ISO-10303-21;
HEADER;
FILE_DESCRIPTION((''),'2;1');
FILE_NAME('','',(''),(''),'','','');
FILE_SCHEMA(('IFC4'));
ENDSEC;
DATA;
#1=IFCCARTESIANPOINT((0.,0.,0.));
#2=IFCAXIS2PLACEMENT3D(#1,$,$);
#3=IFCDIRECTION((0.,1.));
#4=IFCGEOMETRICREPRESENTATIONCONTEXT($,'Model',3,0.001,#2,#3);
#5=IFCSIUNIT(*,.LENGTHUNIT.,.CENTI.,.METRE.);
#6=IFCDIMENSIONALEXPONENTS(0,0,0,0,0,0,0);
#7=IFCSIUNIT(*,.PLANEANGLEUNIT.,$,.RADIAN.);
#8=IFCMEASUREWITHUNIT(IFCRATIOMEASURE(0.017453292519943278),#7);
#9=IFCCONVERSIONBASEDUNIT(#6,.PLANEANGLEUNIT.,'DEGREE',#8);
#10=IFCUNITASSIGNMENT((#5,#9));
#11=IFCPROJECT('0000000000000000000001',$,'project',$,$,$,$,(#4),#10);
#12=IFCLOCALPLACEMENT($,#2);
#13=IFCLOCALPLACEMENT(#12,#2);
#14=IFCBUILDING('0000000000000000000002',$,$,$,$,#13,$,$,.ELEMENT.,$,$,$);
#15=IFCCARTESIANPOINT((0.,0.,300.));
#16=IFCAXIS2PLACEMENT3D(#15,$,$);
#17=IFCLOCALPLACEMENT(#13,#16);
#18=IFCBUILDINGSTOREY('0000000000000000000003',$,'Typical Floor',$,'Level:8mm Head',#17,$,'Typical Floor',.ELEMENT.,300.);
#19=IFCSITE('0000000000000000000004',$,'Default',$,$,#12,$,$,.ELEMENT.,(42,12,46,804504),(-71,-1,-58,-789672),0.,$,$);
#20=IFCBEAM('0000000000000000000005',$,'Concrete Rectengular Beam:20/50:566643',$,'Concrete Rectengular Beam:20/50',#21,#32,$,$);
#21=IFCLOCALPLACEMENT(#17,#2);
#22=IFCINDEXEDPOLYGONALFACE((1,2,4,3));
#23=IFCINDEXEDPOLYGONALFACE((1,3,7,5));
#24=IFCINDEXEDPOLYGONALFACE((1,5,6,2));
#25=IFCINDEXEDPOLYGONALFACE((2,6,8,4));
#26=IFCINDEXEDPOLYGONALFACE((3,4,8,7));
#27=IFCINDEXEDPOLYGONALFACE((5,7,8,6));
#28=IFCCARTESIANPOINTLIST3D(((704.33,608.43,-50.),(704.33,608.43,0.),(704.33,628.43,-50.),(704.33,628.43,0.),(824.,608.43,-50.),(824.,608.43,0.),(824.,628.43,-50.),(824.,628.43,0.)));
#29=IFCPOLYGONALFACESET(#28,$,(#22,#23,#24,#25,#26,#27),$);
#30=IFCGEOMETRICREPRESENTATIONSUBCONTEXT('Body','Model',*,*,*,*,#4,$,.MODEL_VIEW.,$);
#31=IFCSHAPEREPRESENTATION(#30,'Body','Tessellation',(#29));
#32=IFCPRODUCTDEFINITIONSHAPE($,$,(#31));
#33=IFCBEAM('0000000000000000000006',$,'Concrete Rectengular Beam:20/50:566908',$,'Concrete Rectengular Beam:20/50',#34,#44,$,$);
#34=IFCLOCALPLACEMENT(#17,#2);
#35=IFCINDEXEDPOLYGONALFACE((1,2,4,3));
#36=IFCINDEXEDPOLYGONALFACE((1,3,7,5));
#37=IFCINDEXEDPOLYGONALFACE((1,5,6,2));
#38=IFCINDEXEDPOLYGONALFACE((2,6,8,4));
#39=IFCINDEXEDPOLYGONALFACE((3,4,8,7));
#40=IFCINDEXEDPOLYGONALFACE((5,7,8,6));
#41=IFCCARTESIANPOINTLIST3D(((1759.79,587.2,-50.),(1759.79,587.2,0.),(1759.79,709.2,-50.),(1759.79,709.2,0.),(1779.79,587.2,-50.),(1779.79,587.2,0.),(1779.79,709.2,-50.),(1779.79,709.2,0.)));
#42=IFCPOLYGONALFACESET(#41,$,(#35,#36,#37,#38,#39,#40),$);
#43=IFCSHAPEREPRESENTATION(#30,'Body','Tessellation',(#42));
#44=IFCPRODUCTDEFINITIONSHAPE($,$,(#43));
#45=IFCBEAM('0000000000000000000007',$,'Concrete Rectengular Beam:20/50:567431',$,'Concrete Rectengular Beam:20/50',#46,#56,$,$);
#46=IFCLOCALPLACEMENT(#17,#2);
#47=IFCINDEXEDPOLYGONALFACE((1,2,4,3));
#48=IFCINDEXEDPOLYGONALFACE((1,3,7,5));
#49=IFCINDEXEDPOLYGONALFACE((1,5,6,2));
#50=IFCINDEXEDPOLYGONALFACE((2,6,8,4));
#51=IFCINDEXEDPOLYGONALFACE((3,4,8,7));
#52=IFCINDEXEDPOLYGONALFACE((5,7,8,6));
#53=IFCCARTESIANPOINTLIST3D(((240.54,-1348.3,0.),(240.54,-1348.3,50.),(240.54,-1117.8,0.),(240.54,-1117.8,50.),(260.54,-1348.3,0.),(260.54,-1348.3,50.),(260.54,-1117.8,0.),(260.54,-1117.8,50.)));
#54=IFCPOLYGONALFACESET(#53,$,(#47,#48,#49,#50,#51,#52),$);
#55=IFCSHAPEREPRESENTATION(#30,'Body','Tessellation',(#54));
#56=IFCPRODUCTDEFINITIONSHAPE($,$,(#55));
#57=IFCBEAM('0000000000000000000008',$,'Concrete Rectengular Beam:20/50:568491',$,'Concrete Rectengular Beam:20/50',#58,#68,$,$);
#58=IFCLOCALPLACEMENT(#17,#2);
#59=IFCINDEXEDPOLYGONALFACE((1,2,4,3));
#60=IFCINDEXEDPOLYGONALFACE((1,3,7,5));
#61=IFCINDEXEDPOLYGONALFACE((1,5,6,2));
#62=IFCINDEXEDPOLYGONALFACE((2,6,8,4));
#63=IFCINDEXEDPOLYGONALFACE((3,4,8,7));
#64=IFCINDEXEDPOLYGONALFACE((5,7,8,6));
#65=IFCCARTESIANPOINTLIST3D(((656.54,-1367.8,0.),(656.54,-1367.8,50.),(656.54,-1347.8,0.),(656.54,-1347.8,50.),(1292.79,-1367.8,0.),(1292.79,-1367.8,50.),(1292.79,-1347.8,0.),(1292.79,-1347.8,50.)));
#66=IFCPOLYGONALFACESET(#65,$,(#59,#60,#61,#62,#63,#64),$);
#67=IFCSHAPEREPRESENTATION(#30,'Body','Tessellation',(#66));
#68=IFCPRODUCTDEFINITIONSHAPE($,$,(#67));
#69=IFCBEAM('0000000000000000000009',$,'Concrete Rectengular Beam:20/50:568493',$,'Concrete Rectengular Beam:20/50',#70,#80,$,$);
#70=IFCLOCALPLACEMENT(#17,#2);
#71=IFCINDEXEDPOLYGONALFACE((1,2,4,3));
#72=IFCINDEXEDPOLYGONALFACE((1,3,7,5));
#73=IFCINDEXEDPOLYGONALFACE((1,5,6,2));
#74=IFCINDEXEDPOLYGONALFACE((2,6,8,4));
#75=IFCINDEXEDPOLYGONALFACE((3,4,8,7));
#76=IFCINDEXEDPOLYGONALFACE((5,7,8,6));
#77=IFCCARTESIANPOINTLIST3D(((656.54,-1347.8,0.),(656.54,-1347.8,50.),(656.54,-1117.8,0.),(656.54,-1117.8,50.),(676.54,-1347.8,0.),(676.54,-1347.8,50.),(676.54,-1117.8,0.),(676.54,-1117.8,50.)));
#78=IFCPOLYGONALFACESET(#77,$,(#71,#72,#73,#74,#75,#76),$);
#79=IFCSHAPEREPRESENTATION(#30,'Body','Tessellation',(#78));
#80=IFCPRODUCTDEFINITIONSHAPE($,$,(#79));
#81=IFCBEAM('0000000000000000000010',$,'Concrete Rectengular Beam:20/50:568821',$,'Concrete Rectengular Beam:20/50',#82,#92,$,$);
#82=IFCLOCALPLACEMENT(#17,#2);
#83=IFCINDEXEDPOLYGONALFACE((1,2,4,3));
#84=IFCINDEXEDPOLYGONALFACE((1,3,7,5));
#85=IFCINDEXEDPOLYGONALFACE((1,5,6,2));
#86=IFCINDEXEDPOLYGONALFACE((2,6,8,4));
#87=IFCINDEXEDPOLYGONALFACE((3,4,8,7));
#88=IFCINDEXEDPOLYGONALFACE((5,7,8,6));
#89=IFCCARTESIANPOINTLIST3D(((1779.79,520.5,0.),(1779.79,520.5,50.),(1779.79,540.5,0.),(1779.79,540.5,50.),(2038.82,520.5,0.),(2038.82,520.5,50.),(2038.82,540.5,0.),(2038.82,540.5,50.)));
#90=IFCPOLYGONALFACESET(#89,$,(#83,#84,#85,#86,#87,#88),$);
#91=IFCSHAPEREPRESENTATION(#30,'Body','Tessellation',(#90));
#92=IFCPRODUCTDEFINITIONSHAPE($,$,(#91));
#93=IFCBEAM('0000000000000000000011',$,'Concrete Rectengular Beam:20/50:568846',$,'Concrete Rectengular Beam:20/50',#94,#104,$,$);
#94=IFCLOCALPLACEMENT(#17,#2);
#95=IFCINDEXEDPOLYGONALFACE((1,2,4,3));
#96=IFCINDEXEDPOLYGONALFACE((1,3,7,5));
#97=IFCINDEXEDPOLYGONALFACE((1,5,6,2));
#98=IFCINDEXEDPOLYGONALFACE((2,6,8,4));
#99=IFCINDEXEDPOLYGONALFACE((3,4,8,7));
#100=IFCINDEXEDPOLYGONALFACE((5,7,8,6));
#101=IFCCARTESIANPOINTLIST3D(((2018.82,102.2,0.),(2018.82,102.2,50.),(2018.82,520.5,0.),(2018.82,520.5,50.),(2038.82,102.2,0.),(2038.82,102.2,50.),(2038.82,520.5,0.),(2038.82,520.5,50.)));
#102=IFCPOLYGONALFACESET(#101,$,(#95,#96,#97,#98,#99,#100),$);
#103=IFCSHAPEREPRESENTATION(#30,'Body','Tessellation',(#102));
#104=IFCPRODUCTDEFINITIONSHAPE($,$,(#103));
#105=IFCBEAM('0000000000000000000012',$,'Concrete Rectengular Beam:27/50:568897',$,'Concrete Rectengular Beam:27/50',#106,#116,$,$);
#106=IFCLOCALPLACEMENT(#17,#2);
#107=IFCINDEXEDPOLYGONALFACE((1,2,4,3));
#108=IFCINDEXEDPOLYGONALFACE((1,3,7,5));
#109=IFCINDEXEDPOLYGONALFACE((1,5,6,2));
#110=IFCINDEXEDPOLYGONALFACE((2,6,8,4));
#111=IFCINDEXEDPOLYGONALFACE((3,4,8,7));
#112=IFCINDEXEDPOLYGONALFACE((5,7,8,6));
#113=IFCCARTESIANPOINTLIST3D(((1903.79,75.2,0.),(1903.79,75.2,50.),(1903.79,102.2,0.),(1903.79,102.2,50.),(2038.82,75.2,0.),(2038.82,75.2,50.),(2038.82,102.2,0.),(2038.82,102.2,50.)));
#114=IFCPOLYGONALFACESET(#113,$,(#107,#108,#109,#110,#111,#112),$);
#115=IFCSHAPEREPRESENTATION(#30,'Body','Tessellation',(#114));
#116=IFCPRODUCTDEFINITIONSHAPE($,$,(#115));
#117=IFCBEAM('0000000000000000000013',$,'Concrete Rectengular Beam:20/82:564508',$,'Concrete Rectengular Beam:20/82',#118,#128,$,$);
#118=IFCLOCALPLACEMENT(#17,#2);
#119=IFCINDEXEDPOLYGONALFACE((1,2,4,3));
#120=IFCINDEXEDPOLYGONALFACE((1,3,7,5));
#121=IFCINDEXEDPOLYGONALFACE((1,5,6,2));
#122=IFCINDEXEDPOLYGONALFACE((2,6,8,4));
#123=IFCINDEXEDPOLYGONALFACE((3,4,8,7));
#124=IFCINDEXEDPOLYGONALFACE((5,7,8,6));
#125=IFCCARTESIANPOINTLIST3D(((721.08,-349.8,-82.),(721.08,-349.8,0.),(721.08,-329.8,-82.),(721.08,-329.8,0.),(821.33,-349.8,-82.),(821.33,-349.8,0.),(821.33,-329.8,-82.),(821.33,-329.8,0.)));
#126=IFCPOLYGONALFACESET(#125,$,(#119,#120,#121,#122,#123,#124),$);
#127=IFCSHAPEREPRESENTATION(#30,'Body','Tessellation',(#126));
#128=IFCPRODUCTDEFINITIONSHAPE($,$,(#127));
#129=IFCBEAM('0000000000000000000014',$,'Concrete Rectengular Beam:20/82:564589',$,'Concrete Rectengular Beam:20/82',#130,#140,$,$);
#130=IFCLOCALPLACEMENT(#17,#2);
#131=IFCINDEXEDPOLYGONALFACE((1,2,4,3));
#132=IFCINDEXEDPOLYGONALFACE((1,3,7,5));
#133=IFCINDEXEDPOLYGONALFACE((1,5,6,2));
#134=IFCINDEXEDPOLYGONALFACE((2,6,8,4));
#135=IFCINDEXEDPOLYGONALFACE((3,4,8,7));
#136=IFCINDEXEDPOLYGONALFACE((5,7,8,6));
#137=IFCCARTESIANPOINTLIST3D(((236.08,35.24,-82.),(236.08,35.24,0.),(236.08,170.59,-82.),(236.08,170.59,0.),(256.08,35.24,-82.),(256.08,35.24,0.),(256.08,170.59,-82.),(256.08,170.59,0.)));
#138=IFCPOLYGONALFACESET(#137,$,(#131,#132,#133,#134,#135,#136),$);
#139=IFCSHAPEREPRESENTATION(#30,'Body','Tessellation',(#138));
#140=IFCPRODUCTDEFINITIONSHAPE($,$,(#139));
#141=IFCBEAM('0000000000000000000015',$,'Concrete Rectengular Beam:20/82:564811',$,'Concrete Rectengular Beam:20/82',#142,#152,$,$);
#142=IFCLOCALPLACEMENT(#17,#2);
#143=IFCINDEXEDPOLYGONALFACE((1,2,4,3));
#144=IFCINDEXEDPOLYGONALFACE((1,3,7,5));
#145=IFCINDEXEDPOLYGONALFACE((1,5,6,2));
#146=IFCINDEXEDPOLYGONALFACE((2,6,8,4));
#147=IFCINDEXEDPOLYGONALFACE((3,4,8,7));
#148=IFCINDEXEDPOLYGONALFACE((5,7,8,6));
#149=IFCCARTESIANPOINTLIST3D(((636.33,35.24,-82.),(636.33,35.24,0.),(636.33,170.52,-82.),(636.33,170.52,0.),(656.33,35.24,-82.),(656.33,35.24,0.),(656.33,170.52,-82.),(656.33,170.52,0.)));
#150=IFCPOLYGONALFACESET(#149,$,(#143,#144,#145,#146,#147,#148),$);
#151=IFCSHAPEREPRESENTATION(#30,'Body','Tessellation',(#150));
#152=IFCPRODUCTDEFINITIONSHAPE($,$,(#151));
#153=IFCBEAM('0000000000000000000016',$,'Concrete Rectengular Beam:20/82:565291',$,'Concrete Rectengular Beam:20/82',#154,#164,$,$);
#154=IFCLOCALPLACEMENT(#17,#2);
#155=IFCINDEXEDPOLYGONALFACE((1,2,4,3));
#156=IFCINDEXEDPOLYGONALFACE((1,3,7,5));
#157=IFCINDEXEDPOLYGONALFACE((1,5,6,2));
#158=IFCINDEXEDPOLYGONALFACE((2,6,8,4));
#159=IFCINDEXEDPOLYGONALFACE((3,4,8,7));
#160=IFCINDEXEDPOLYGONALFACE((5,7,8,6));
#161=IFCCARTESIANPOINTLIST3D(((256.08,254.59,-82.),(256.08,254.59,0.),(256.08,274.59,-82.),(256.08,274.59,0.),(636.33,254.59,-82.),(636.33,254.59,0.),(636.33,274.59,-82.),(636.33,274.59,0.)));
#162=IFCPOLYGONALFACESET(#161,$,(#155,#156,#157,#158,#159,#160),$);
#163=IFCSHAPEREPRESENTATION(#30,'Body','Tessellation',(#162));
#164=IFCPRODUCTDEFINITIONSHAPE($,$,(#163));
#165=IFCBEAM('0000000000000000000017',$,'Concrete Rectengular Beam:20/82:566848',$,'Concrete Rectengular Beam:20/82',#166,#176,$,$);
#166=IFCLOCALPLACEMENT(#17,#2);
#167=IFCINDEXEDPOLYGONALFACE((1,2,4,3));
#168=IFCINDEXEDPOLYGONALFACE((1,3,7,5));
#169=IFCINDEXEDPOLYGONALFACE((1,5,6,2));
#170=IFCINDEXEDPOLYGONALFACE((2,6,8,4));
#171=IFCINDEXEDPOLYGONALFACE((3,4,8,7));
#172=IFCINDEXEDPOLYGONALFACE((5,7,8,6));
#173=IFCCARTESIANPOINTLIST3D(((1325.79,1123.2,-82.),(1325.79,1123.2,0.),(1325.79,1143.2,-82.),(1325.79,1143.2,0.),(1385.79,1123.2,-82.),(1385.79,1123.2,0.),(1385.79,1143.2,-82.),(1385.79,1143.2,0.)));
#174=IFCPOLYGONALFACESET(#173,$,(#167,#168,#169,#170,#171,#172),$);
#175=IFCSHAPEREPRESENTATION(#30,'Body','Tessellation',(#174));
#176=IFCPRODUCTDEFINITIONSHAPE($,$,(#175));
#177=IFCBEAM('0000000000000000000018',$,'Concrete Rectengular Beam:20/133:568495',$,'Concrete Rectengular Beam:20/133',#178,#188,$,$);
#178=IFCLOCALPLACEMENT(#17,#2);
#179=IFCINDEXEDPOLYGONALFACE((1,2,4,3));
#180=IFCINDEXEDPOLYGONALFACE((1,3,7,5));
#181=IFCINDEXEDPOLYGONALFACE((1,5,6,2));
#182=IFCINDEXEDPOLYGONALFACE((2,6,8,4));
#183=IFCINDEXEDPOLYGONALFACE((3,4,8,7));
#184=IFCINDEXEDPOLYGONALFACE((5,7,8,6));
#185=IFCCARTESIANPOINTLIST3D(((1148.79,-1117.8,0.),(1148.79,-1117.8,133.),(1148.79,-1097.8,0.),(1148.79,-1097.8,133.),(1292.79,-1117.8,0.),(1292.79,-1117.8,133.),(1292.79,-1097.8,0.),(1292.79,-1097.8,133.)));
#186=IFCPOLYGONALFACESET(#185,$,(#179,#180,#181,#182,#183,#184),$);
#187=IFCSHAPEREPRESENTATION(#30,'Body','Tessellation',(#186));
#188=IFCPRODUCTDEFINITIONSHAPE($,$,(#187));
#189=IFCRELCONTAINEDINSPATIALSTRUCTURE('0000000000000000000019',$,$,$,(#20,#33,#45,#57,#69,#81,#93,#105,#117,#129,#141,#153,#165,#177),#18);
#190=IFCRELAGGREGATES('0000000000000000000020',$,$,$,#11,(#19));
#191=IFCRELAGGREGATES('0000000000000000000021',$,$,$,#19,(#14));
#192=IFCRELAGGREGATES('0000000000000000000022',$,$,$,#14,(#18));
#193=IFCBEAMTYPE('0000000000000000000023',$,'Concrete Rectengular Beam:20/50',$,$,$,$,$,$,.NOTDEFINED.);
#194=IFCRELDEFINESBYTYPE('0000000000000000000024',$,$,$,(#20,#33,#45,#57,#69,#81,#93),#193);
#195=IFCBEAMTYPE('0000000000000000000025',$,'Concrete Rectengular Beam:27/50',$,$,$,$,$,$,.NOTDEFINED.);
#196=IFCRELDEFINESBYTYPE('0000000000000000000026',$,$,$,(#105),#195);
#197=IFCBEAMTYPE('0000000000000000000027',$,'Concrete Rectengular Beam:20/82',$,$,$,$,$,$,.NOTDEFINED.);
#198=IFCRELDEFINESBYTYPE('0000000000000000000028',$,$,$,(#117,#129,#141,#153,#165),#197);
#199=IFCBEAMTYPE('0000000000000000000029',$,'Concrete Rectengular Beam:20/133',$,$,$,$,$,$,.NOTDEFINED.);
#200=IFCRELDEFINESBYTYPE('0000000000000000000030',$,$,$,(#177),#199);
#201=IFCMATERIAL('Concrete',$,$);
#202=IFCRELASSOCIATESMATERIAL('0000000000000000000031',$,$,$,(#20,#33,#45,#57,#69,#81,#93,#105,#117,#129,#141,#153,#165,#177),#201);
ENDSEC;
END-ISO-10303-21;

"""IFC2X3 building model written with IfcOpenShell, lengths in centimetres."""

from ifc_helpers import new_model, entity, si_unit, converted_unit, direction, frame, frame_2d, origin, origin_2d_with_axis, place, context, subcontext, project, spatial, rectangle, extrude, material, type_object, element, save


model = new_model("IFC2X3")

# Units and contexts
model_context = context("Model", 3, precision=0.001, world=origin(), true_north=direction((0.0, 1.0)))
body_context = subcontext(model_context, "Body", "Model", "MODEL_VIEW")
ifc_project = project(units=[si_unit("LENGTHUNIT", "METRE", prefix="CENTI"), converted_unit("PLANEANGLEUNIT", "DEGREE", entity("IfcRatioMeasure", 0.017453292519943278), si_unit("PLANEANGLEUNIT", "RADIAN"), dimensions=[0, 0, 0, 0, 0, 0, 0])], contexts=[model_context])

# Site, building, storey
site_placement = place(None, origin())
site = spatial("IfcSite", under=ifc_project, at=site_placement, Name="Default", CompositionType="ELEMENT", RefLatitude=(42, 12, 46, 804504), RefLongitude=(-71, -1, -58, -789672), RefElevation=0.0)
building_placement = place(site_placement, origin())
building = spatial("IfcBuilding", under=site, at=building_placement, CompositionType="ELEMENT")
storey_placement = place(building_placement, frame((0.0, 0.0, 300.0)))
storey = spatial("IfcBuildingStorey", under=building, at=storey_placement, Name="Typical Floor", ObjectType="Level:8mm Head", LongName="Typical Floor", CompositionType="ELEMENT", Elevation=300.0)

# Beams
ifc_material = material(Name="Concrete")
beam_type_1 = type_object("IfcBeamType", Name="Concrete Rectengular Beam:20/50", PredefinedType="NOTDEFINED")
beam_1_placement = place(storey_placement, frame((694.33, 618.43, 0.0)))
element("IfcBeam", 1, at=beam_1_placement, inside=storey, type_object=beam_type_1, material=ifc_material, Name="Concrete Rectengular Beam:20/50:566643", ObjectType="Concrete Rectengular Beam:20/50", context=body_context, shape_type="SweptSolid", body=[
    extrude(rectangle(XDim=50.0, YDim=20.0, at=frame_2d((0.0, 0.0), x_axis=(1.0, 0.0))), frame((10.0, 0.0, -25.0), z_axis=(1.0, 0.0, 0.0), x_axis=(0.0, 0.0, -1.0)), (0.0, 0.0, 1.0), 119.67),
])
beam_2_placement = place(storey_placement, frame((1769.79, 729.2, 0.0), z_axis=(0.0, 0.0, 1.0), x_axis=(0.0, -1.0, 0.0)))
element("IfcBeam", 2, at=beam_2_placement, inside=storey, type_object=beam_type_1, material=ifc_material, Name="Concrete Rectengular Beam:20/50:566908", ObjectType="Concrete Rectengular Beam:20/50", context=body_context, shape_type="SweptSolid", body=[
    extrude(rectangle(XDim=50.0, YDim=20.0, at=frame_2d((0.0, 0.0), x_axis=(1.0, 0.0))), frame((20.0, 0.0, -25.0), z_axis=(1.0, 0.0, 0.0), x_axis=(0.0, 0.0, -1.0)), (0.0, 0.0, 1.0), 122.0),
])
beam_3_placement = place(storey_placement, frame((250.54, -1358.3, 0.0), z_axis=(0.0, 0.0, 1.0), x_axis=(0.0, 1.0, 0.0)))
element("IfcBeam", 3, at=beam_3_placement, inside=storey, type_object=beam_type_1, material=ifc_material, Name="Concrete Rectengular Beam:20/50:567431", ObjectType="Concrete Rectengular Beam:20/50", context=body_context, shape_type="SweptSolid", body=[
    extrude(rectangle(XDim=50.0, YDim=20.0, at=origin_2d_with_axis()), frame((10.0, 0.0, 25.0), z_axis=(1.0, 0.0, 0.0), x_axis=(0.0, 0.0, -1.0)), (0.0, 0.0, 1.0), 230.5),
])
beam_4_placement = place(storey_placement, frame((1292.79, -1357.8, 0.0), z_axis=(0.0, 0.0, 1.0), x_axis=(-1.0, 0.0, 0.0)))
element("IfcBeam", 4, at=beam_4_placement, inside=storey, type_object=beam_type_1, material=ifc_material, Name="Concrete Rectengular Beam:20/50:568491", ObjectType="Concrete Rectengular Beam:20/50", context=body_context, shape_type="SweptSolid", body=[
    extrude(rectangle(XDim=50.0, YDim=20.0, at=frame_2d((0.0, 0.0), x_axis=(1.0, 0.0))), frame((0.0, 0.0, 25.0), z_axis=(1.0, 0.0, 0.0), x_axis=(0.0, 0.0, -1.0)), (0.0, 0.0, 1.0), 636.25),
])
beam_5_placement = place(storey_placement, frame((666.54, -1357.8, 0.0), z_axis=(0.0, 0.0, 1.0), x_axis=(0.0, 1.0, 0.0)))
element("IfcBeam", 5, at=beam_5_placement, inside=storey, type_object=beam_type_1, material=ifc_material, Name="Concrete Rectengular Beam:20/50:568493", ObjectType="Concrete Rectengular Beam:20/50", context=body_context, shape_type="SweptSolid", body=[
    extrude(rectangle(XDim=50.0, YDim=20.0, at=origin_2d_with_axis()), frame((10.0, 0.0, 25.0), z_axis=(1.0, 0.0, 0.0), x_axis=(0.0, 0.0, -1.0)), (0.0, 0.0, 1.0), 230.0),
])
beam_6_placement = place(storey_placement, frame((1779.79, 530.5, 0.0)))
element("IfcBeam", 6, at=beam_6_placement, inside=storey, type_object=beam_type_1, material=ifc_material, Name="Concrete Rectengular Beam:20/50:568821", ObjectType="Concrete Rectengular Beam:20/50", context=body_context, shape_type="SweptSolid", body=[
    extrude(rectangle(XDim=50.0, YDim=20.0, at=frame_2d((0.0, 0.0), x_axis=(1.0, 0.0))), frame((0.0, 0.0, 25.0), z_axis=(1.0, 0.0, 0.0), x_axis=(0.0, 0.0, -1.0)), (0.0, 0.0, 1.0), 259.03),
])
beam_7_placement = place(storey_placement, frame((2028.82, 530.5, 0.0), z_axis=(0.0, 0.0, 1.0), x_axis=(0.0, -1.0, 0.0)))
element("IfcBeam", 7, at=beam_7_placement, inside=storey, type_object=beam_type_1, material=ifc_material, Name="Concrete Rectengular Beam:20/50:568846", ObjectType="Concrete Rectengular Beam:20/50", context=body_context, shape_type="SweptSolid", body=[
    extrude(rectangle(XDim=50.0, YDim=20.0, at=frame_2d((0.0, 0.0), x_axis=(1.0, 0.0))), frame((10.0, 0.0, 25.0), z_axis=(1.0, 0.0, 0.0), x_axis=(0.0, 0.0, -1.0)), (0.0, 0.0, 1.0), 418.3),
])
beam_type_2 = type_object("IfcBeamType", Name="Concrete Rectengular Beam:27/50", PredefinedType="NOTDEFINED")
beam_8_placement = place(storey_placement, frame((1903.79, 88.7, 0.0)))
element("IfcBeam", 8, at=beam_8_placement, inside=storey, type_object=beam_type_2, material=ifc_material, Name="Concrete Rectengular Beam:27/50:568897", ObjectType="Concrete Rectengular Beam:27/50", context=body_context, shape_type="SweptSolid", body=[
    extrude(rectangle(XDim=50.0, YDim=27.0, at=frame_2d((0.0, 0.0), x_axis=(1.0, 0.0))), frame((0.0, 0.0, 25.0), z_axis=(1.0, 0.0, 0.0), x_axis=(0.0, 0.0, -1.0)), (0.0, 0.0, 1.0), 135.03),
])
beam_type_3 = type_object("IfcBeamType", Name="Concrete Rectengular Beam:20/82", PredefinedType="NOTDEFINED")
beam_9_placement = place(storey_placement, frame((711.08, -339.8, 0.0)))
element("IfcBeam", 9, at=beam_9_placement, inside=storey, type_object=beam_type_3, material=ifc_material, Name="Concrete Rectengular Beam:20/82:564508", ObjectType="Concrete Rectengular Beam:20/82", context=body_context, shape_type="SweptSolid", body=[
    extrude(rectangle(XDim=82.0, YDim=20.0, at=frame_2d((0.0, 0.0), x_axis=(1.0, 0.0))), frame((10.0, 0.0, -41.0), z_axis=(1.0, 0.0, 0.0), x_axis=(0.0, 0.0, -1.0)), (0.0, 0.0, 1.0), 100.25),
])
beam_10_placement = place(storey_placement, frame((246.08, 15.24, 0.0), z_axis=(0.0, 0.0, 1.0), x_axis=(0.0, 1.0, 0.0)))
element("IfcBeam", 10, at=beam_10_placement, inside=storey, type_object=beam_type_3, material=ifc_material, Name="Concrete Rectengular Beam:20/82:564589", ObjectType="Concrete Rectengular Beam:20/82", context=body_context, shape_type="SweptSolid", body=[
    extrude(rectangle(XDim=82.0, YDim=20.0, at=frame_2d((0.0, 0.0), x_axis=(1.0, 0.0))), frame((20.0, 0.0, -41.0), z_axis=(1.0, 0.0, 0.0), x_axis=(0.0, 0.0, -1.0)), (0.0, 0.0, 1.0), 135.35),
])
beam_11_placement = place(storey_placement, frame((646.33, 15.24, 0.0), z_axis=(0.0, 0.0, 1.0), x_axis=(0.0, 1.0, 0.0)))
element("IfcBeam", 11, at=beam_11_placement, inside=storey, type_object=beam_type_3, material=ifc_material, Name="Concrete Rectengular Beam:20/82:564811", ObjectType="Concrete Rectengular Beam:20/82", context=body_context, shape_type="SweptSolid", body=[
    extrude(rectangle(XDim=82.0, YDim=20.0, at=origin_2d_with_axis()), frame((20.0, 0.0, -41.0), z_axis=(1.0, 0.0, 0.0), x_axis=(0.0, 0.0, -1.0)), (0.0, 0.0, 1.0), 135.28),
])
beam_12_placement = place(storey_placement, frame((246.08, 264.59, 0.0)))
element("IfcBeam", 12, at=beam_12_placement, inside=storey, type_object=beam_type_3, material=ifc_material, Name="Concrete Rectengular Beam:20/82:565291", ObjectType="Concrete Rectengular Beam:20/82", context=body_context, shape_type="SweptSolid", body=[
    extrude(rectangle(XDim=82.0, YDim=20.0, at=frame_2d((0.0, 0.0), x_axis=(1.0, 0.0))), frame((10.0, 0.0, -41.0), z_axis=(1.0, 0.0, 0.0), x_axis=(0.0, 0.0, -1.0)), (0.0, 0.0, 1.0), 380.25),
])
beam_13_placement = place(storey_placement, frame((1305.79, 1133.2, 0.0)))
element("IfcBeam", 13, at=beam_13_placement, inside=storey, type_object=beam_type_3, material=ifc_material, Name="Concrete Rectengular Beam:20/82:566848", ObjectType="Concrete Rectengular Beam:20/82", context=body_context, shape_type="SweptSolid", body=[
    extrude(rectangle(XDim=82.0, YDim=20.0, at=origin_2d_with_axis()), frame((20.0, 0.0, -41.0), z_axis=(1.0, 0.0, 0.0), x_axis=(0.0, 0.0, -1.0)), (0.0, 0.0, 1.0), 60.0),
])
beam_type_4 = type_object("IfcBeamType", Name="Concrete Rectengular Beam:20/133", PredefinedType="NOTDEFINED")
beam_14_placement = place(storey_placement, frame((1148.79, -1107.8, 0.0)))
element("IfcBeam", 14, at=beam_14_placement, inside=storey, type_object=beam_type_4, material=ifc_material, Name="Concrete Rectengular Beam:20/133:568495", ObjectType="Concrete Rectengular Beam:20/133", context=body_context, shape_type="SweptSolid", body=[
    extrude(rectangle(XDim=133.0, YDim=20.0, at=frame_2d((0.0, 0.0), x_axis=(1.0, 0.0))), frame((0.0, 0.0, 66.5), z_axis=(1.0, 0.0, 0.0), x_axis=(0.0, 0.0, -1.0)), (0.0, 0.0, 1.0), 144.0),
])

save(model, "model.ifc")
